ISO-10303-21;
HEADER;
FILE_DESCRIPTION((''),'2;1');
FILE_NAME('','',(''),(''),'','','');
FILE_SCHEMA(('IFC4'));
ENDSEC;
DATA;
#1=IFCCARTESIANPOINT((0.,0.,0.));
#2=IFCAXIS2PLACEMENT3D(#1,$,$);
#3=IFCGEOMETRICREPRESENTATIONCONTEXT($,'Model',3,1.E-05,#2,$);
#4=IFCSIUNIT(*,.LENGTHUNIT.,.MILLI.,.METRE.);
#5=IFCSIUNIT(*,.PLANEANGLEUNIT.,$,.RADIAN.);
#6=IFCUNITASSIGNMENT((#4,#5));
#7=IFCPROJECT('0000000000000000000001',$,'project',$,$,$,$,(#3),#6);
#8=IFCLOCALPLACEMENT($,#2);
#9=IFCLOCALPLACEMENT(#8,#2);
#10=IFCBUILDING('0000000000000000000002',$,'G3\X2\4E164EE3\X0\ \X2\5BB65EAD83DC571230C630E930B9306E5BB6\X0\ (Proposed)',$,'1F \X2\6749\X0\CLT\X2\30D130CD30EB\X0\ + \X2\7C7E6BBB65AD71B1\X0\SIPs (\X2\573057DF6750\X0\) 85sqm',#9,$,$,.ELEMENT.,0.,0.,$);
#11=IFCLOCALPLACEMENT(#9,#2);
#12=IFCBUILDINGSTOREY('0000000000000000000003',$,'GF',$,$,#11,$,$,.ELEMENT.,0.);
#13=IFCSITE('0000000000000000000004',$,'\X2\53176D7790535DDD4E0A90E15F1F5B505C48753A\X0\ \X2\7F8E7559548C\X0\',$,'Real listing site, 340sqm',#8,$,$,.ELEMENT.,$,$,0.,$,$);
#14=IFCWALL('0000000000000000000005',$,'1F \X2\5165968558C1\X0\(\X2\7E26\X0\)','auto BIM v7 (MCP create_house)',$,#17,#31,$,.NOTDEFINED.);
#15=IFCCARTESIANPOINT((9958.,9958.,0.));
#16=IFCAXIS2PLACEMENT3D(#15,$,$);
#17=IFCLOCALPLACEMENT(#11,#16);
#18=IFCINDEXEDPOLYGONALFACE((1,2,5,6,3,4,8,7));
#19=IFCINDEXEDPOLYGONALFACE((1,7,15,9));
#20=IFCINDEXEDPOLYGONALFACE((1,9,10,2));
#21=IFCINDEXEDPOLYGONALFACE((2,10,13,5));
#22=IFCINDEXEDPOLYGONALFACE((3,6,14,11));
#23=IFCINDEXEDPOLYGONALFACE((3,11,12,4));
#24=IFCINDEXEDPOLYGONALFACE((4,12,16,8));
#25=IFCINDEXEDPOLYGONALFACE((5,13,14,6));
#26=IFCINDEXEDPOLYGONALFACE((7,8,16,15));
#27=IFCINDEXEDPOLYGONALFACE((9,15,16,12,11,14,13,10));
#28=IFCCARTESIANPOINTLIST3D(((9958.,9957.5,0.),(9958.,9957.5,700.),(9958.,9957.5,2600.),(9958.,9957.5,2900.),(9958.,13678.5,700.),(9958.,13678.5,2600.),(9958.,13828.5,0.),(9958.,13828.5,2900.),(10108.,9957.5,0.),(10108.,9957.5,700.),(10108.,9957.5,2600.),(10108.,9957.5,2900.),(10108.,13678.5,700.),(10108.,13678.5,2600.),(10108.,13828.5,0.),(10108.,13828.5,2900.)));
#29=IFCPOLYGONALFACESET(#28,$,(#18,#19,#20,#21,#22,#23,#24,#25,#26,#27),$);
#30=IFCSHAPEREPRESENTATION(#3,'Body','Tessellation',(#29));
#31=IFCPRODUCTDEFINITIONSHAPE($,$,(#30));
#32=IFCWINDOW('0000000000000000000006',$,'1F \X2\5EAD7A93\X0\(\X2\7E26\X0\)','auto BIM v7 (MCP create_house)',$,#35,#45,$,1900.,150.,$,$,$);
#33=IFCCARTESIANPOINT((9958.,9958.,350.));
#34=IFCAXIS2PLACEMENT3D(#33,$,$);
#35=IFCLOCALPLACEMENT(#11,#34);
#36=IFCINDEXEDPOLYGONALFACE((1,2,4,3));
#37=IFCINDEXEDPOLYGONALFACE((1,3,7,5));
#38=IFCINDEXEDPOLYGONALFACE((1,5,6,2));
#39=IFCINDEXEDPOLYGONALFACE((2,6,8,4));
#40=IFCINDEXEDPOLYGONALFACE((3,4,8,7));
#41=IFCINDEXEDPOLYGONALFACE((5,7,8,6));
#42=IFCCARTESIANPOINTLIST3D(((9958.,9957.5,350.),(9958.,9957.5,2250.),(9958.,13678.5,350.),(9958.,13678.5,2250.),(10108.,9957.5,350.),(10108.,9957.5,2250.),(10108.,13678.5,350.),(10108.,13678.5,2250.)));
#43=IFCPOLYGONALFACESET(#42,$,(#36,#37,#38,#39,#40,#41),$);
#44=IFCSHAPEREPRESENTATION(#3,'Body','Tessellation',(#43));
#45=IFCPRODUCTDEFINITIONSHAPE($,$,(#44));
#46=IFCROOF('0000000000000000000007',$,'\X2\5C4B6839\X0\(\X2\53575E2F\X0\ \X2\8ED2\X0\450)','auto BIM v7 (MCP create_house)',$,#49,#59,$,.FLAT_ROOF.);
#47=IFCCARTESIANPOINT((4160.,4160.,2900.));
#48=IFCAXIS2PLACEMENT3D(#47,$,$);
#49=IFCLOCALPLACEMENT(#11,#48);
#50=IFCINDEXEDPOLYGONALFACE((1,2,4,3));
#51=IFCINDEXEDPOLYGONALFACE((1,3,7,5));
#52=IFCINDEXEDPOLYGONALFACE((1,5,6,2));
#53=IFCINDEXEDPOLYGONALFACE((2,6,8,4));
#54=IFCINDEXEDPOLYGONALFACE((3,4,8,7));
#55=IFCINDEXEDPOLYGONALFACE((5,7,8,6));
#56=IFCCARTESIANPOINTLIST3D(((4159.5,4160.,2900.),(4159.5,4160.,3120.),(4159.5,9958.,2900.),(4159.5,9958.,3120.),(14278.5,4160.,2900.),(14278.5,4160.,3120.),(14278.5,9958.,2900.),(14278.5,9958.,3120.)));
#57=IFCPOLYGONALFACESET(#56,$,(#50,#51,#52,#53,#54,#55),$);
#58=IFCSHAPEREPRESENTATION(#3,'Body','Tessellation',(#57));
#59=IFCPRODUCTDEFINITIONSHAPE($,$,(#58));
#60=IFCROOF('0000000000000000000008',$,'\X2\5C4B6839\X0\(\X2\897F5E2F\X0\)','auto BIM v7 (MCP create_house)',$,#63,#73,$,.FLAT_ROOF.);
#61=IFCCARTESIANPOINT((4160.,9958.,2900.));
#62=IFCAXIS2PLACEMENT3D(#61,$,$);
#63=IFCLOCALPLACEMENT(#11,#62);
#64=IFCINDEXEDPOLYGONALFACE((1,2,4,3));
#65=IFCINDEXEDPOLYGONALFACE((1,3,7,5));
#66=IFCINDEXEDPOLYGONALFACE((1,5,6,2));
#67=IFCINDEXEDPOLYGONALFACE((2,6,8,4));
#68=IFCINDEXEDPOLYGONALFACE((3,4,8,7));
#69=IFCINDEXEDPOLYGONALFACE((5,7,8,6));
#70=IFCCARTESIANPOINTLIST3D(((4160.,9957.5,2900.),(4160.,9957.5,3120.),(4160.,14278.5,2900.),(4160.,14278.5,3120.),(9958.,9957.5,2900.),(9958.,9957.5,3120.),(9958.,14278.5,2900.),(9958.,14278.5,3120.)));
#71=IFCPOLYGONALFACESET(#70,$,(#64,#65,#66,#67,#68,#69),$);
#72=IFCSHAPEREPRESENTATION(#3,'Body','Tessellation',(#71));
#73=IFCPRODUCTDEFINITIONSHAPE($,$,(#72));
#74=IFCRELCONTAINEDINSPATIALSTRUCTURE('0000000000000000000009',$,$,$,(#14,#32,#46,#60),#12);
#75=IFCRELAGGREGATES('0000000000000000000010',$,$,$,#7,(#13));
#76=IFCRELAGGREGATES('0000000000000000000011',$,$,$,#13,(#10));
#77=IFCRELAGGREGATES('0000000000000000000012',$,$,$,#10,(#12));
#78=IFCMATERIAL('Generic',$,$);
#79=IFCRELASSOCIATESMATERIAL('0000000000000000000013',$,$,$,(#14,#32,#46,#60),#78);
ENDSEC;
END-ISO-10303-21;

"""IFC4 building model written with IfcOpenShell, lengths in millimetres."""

from ifc_helpers import new_model, si_unit, frame, frame_2d, origin, place, context, project, spatial, rectangle, extrude, material, element, fill, save


model = new_model("IFC4")

# Units and contexts
model_context = context("Model", 3, precision=1e-05, world=origin())
ifc_project = project(units=[si_unit("LENGTHUNIT", "METRE", prefix="MILLI"), si_unit("PLANEANGLEUNIT", "RADIAN")], contexts=[model_context])

# Site, building, storey
site_placement = place(None, origin())
site = spatial("IfcSite", under=ifc_project, at=site_placement, Name="北海道川上郡弟子屈町 美留和", ObjectType="Real listing site, 340sqm", CompositionType="ELEMENT", RefElevation=0.0)
building_placement = place(site_placement, origin())
building = spatial("IfcBuilding", under=site, at=building_placement, Name="G3世代 家庭菜園テラスの家 (Proposed)", ObjectType="1F 杉CLTパネル + 籾殻断熱SIPs (地域材) 85sqm", CompositionType="ELEMENT", ElevationOfRefHeight=0.0, ElevationOfTerrain=0.0)
storey_placement = place(building_placement, origin())
storey = spatial("IfcBuildingStorey", under=building, at=storey_placement, Name="GF", CompositionType="ELEMENT", Elevation=0.0)

# Shared definitions
ifc_material = material(Name="Generic")

# Wall, opening, window
wall_1_placement = place(storey_placement, frame((9958.0, 9958.0, 0.0)))
wall_1 = element("IfcWall", 1, at=wall_1_placement, inside=storey, material=ifc_material, Name="1F 入隅壁(縦)", Description="auto BIM v7 (MCP create_house)", PredefinedType="NOTDEFINED", context=model_context, shape_type="SweptSolid", body=[
    extrude(rectangle(XDim=150.0, YDim=3871.0, at=frame_2d((75.0, 1935.0))), frame((9958.0, 9958.0, 0.0)), (0.0, 0.0, 1.0), 2900.0),
])
opening_1_placement = place(storey_placement, frame((9958.0, 9958.0, 350.0)))
opening_1 = element("IfcOpeningElement", 2, at=opening_1_placement, cuts=wall_1, PredefinedType="NOTDEFINED", context=model_context, shape_type="SweptSolid", body=[
    extrude(rectangle(XDim=150.0, YDim=3721.0, at=frame_2d((75.0, 1860.0))), frame((9958.0, 9958.0, 350.0)), (0.0, 0.0, 1.0), 1900.0),
])
window_1_placement = place(storey_placement, frame((9958.0, 9958.0, 350.0)))
window_1 = element("IfcWindow", 3, at=window_1_placement, inside=storey, material=ifc_material, Name="1F 庭窓(縦)", Description="auto BIM v7 (MCP create_house)", OverallHeight=1900.0, OverallWidth=150.0, context=model_context, shape_type="SweptSolid", body=[
    extrude(rectangle(XDim=150.0, YDim=3721.0, at=frame_2d((75.0, 1860.0))), frame((9958.0, 9958.0, 350.0)), (0.0, 0.0, 1.0), 1900.0),
])
fill(opening_1, window_1)

# Roofs
roof_1_placement = place(storey_placement, frame((4160.0, 4160.0, 2900.0)))
element("IfcRoof", 4, at=roof_1_placement, inside=storey, material=ifc_material, Name="屋根(南帯 軒450)", Description="auto BIM v7 (MCP create_house)", PredefinedType="FLAT_ROOF", context=model_context, shape_type="SweptSolid", body=[
    extrude(rectangle(XDim=10119.0, YDim=5798.0, at=frame_2d((5059.0, 2899.0))), frame((4160.0, 4160.0, 2900.0)), (0.0, 0.0, 1.0), 220.0),
])
roof_2_placement = place(storey_placement, frame((4160.0, 9958.0, 2900.0)))
element("IfcRoof", 5, at=roof_2_placement, inside=storey, material=ifc_material, Name="屋根(西帯)", Description="auto BIM v7 (MCP create_house)", PredefinedType="FLAT_ROOF", context=model_context, shape_type="SweptSolid", body=[
    extrude(rectangle(XDim=5798.0, YDim=4321.0, at=frame_2d((2899.0, 2160.0))), frame((4160.0, 9958.0, 2900.0)), (0.0, 0.0, 1.0), 220.0),
])

save(model, "model.ifc")
